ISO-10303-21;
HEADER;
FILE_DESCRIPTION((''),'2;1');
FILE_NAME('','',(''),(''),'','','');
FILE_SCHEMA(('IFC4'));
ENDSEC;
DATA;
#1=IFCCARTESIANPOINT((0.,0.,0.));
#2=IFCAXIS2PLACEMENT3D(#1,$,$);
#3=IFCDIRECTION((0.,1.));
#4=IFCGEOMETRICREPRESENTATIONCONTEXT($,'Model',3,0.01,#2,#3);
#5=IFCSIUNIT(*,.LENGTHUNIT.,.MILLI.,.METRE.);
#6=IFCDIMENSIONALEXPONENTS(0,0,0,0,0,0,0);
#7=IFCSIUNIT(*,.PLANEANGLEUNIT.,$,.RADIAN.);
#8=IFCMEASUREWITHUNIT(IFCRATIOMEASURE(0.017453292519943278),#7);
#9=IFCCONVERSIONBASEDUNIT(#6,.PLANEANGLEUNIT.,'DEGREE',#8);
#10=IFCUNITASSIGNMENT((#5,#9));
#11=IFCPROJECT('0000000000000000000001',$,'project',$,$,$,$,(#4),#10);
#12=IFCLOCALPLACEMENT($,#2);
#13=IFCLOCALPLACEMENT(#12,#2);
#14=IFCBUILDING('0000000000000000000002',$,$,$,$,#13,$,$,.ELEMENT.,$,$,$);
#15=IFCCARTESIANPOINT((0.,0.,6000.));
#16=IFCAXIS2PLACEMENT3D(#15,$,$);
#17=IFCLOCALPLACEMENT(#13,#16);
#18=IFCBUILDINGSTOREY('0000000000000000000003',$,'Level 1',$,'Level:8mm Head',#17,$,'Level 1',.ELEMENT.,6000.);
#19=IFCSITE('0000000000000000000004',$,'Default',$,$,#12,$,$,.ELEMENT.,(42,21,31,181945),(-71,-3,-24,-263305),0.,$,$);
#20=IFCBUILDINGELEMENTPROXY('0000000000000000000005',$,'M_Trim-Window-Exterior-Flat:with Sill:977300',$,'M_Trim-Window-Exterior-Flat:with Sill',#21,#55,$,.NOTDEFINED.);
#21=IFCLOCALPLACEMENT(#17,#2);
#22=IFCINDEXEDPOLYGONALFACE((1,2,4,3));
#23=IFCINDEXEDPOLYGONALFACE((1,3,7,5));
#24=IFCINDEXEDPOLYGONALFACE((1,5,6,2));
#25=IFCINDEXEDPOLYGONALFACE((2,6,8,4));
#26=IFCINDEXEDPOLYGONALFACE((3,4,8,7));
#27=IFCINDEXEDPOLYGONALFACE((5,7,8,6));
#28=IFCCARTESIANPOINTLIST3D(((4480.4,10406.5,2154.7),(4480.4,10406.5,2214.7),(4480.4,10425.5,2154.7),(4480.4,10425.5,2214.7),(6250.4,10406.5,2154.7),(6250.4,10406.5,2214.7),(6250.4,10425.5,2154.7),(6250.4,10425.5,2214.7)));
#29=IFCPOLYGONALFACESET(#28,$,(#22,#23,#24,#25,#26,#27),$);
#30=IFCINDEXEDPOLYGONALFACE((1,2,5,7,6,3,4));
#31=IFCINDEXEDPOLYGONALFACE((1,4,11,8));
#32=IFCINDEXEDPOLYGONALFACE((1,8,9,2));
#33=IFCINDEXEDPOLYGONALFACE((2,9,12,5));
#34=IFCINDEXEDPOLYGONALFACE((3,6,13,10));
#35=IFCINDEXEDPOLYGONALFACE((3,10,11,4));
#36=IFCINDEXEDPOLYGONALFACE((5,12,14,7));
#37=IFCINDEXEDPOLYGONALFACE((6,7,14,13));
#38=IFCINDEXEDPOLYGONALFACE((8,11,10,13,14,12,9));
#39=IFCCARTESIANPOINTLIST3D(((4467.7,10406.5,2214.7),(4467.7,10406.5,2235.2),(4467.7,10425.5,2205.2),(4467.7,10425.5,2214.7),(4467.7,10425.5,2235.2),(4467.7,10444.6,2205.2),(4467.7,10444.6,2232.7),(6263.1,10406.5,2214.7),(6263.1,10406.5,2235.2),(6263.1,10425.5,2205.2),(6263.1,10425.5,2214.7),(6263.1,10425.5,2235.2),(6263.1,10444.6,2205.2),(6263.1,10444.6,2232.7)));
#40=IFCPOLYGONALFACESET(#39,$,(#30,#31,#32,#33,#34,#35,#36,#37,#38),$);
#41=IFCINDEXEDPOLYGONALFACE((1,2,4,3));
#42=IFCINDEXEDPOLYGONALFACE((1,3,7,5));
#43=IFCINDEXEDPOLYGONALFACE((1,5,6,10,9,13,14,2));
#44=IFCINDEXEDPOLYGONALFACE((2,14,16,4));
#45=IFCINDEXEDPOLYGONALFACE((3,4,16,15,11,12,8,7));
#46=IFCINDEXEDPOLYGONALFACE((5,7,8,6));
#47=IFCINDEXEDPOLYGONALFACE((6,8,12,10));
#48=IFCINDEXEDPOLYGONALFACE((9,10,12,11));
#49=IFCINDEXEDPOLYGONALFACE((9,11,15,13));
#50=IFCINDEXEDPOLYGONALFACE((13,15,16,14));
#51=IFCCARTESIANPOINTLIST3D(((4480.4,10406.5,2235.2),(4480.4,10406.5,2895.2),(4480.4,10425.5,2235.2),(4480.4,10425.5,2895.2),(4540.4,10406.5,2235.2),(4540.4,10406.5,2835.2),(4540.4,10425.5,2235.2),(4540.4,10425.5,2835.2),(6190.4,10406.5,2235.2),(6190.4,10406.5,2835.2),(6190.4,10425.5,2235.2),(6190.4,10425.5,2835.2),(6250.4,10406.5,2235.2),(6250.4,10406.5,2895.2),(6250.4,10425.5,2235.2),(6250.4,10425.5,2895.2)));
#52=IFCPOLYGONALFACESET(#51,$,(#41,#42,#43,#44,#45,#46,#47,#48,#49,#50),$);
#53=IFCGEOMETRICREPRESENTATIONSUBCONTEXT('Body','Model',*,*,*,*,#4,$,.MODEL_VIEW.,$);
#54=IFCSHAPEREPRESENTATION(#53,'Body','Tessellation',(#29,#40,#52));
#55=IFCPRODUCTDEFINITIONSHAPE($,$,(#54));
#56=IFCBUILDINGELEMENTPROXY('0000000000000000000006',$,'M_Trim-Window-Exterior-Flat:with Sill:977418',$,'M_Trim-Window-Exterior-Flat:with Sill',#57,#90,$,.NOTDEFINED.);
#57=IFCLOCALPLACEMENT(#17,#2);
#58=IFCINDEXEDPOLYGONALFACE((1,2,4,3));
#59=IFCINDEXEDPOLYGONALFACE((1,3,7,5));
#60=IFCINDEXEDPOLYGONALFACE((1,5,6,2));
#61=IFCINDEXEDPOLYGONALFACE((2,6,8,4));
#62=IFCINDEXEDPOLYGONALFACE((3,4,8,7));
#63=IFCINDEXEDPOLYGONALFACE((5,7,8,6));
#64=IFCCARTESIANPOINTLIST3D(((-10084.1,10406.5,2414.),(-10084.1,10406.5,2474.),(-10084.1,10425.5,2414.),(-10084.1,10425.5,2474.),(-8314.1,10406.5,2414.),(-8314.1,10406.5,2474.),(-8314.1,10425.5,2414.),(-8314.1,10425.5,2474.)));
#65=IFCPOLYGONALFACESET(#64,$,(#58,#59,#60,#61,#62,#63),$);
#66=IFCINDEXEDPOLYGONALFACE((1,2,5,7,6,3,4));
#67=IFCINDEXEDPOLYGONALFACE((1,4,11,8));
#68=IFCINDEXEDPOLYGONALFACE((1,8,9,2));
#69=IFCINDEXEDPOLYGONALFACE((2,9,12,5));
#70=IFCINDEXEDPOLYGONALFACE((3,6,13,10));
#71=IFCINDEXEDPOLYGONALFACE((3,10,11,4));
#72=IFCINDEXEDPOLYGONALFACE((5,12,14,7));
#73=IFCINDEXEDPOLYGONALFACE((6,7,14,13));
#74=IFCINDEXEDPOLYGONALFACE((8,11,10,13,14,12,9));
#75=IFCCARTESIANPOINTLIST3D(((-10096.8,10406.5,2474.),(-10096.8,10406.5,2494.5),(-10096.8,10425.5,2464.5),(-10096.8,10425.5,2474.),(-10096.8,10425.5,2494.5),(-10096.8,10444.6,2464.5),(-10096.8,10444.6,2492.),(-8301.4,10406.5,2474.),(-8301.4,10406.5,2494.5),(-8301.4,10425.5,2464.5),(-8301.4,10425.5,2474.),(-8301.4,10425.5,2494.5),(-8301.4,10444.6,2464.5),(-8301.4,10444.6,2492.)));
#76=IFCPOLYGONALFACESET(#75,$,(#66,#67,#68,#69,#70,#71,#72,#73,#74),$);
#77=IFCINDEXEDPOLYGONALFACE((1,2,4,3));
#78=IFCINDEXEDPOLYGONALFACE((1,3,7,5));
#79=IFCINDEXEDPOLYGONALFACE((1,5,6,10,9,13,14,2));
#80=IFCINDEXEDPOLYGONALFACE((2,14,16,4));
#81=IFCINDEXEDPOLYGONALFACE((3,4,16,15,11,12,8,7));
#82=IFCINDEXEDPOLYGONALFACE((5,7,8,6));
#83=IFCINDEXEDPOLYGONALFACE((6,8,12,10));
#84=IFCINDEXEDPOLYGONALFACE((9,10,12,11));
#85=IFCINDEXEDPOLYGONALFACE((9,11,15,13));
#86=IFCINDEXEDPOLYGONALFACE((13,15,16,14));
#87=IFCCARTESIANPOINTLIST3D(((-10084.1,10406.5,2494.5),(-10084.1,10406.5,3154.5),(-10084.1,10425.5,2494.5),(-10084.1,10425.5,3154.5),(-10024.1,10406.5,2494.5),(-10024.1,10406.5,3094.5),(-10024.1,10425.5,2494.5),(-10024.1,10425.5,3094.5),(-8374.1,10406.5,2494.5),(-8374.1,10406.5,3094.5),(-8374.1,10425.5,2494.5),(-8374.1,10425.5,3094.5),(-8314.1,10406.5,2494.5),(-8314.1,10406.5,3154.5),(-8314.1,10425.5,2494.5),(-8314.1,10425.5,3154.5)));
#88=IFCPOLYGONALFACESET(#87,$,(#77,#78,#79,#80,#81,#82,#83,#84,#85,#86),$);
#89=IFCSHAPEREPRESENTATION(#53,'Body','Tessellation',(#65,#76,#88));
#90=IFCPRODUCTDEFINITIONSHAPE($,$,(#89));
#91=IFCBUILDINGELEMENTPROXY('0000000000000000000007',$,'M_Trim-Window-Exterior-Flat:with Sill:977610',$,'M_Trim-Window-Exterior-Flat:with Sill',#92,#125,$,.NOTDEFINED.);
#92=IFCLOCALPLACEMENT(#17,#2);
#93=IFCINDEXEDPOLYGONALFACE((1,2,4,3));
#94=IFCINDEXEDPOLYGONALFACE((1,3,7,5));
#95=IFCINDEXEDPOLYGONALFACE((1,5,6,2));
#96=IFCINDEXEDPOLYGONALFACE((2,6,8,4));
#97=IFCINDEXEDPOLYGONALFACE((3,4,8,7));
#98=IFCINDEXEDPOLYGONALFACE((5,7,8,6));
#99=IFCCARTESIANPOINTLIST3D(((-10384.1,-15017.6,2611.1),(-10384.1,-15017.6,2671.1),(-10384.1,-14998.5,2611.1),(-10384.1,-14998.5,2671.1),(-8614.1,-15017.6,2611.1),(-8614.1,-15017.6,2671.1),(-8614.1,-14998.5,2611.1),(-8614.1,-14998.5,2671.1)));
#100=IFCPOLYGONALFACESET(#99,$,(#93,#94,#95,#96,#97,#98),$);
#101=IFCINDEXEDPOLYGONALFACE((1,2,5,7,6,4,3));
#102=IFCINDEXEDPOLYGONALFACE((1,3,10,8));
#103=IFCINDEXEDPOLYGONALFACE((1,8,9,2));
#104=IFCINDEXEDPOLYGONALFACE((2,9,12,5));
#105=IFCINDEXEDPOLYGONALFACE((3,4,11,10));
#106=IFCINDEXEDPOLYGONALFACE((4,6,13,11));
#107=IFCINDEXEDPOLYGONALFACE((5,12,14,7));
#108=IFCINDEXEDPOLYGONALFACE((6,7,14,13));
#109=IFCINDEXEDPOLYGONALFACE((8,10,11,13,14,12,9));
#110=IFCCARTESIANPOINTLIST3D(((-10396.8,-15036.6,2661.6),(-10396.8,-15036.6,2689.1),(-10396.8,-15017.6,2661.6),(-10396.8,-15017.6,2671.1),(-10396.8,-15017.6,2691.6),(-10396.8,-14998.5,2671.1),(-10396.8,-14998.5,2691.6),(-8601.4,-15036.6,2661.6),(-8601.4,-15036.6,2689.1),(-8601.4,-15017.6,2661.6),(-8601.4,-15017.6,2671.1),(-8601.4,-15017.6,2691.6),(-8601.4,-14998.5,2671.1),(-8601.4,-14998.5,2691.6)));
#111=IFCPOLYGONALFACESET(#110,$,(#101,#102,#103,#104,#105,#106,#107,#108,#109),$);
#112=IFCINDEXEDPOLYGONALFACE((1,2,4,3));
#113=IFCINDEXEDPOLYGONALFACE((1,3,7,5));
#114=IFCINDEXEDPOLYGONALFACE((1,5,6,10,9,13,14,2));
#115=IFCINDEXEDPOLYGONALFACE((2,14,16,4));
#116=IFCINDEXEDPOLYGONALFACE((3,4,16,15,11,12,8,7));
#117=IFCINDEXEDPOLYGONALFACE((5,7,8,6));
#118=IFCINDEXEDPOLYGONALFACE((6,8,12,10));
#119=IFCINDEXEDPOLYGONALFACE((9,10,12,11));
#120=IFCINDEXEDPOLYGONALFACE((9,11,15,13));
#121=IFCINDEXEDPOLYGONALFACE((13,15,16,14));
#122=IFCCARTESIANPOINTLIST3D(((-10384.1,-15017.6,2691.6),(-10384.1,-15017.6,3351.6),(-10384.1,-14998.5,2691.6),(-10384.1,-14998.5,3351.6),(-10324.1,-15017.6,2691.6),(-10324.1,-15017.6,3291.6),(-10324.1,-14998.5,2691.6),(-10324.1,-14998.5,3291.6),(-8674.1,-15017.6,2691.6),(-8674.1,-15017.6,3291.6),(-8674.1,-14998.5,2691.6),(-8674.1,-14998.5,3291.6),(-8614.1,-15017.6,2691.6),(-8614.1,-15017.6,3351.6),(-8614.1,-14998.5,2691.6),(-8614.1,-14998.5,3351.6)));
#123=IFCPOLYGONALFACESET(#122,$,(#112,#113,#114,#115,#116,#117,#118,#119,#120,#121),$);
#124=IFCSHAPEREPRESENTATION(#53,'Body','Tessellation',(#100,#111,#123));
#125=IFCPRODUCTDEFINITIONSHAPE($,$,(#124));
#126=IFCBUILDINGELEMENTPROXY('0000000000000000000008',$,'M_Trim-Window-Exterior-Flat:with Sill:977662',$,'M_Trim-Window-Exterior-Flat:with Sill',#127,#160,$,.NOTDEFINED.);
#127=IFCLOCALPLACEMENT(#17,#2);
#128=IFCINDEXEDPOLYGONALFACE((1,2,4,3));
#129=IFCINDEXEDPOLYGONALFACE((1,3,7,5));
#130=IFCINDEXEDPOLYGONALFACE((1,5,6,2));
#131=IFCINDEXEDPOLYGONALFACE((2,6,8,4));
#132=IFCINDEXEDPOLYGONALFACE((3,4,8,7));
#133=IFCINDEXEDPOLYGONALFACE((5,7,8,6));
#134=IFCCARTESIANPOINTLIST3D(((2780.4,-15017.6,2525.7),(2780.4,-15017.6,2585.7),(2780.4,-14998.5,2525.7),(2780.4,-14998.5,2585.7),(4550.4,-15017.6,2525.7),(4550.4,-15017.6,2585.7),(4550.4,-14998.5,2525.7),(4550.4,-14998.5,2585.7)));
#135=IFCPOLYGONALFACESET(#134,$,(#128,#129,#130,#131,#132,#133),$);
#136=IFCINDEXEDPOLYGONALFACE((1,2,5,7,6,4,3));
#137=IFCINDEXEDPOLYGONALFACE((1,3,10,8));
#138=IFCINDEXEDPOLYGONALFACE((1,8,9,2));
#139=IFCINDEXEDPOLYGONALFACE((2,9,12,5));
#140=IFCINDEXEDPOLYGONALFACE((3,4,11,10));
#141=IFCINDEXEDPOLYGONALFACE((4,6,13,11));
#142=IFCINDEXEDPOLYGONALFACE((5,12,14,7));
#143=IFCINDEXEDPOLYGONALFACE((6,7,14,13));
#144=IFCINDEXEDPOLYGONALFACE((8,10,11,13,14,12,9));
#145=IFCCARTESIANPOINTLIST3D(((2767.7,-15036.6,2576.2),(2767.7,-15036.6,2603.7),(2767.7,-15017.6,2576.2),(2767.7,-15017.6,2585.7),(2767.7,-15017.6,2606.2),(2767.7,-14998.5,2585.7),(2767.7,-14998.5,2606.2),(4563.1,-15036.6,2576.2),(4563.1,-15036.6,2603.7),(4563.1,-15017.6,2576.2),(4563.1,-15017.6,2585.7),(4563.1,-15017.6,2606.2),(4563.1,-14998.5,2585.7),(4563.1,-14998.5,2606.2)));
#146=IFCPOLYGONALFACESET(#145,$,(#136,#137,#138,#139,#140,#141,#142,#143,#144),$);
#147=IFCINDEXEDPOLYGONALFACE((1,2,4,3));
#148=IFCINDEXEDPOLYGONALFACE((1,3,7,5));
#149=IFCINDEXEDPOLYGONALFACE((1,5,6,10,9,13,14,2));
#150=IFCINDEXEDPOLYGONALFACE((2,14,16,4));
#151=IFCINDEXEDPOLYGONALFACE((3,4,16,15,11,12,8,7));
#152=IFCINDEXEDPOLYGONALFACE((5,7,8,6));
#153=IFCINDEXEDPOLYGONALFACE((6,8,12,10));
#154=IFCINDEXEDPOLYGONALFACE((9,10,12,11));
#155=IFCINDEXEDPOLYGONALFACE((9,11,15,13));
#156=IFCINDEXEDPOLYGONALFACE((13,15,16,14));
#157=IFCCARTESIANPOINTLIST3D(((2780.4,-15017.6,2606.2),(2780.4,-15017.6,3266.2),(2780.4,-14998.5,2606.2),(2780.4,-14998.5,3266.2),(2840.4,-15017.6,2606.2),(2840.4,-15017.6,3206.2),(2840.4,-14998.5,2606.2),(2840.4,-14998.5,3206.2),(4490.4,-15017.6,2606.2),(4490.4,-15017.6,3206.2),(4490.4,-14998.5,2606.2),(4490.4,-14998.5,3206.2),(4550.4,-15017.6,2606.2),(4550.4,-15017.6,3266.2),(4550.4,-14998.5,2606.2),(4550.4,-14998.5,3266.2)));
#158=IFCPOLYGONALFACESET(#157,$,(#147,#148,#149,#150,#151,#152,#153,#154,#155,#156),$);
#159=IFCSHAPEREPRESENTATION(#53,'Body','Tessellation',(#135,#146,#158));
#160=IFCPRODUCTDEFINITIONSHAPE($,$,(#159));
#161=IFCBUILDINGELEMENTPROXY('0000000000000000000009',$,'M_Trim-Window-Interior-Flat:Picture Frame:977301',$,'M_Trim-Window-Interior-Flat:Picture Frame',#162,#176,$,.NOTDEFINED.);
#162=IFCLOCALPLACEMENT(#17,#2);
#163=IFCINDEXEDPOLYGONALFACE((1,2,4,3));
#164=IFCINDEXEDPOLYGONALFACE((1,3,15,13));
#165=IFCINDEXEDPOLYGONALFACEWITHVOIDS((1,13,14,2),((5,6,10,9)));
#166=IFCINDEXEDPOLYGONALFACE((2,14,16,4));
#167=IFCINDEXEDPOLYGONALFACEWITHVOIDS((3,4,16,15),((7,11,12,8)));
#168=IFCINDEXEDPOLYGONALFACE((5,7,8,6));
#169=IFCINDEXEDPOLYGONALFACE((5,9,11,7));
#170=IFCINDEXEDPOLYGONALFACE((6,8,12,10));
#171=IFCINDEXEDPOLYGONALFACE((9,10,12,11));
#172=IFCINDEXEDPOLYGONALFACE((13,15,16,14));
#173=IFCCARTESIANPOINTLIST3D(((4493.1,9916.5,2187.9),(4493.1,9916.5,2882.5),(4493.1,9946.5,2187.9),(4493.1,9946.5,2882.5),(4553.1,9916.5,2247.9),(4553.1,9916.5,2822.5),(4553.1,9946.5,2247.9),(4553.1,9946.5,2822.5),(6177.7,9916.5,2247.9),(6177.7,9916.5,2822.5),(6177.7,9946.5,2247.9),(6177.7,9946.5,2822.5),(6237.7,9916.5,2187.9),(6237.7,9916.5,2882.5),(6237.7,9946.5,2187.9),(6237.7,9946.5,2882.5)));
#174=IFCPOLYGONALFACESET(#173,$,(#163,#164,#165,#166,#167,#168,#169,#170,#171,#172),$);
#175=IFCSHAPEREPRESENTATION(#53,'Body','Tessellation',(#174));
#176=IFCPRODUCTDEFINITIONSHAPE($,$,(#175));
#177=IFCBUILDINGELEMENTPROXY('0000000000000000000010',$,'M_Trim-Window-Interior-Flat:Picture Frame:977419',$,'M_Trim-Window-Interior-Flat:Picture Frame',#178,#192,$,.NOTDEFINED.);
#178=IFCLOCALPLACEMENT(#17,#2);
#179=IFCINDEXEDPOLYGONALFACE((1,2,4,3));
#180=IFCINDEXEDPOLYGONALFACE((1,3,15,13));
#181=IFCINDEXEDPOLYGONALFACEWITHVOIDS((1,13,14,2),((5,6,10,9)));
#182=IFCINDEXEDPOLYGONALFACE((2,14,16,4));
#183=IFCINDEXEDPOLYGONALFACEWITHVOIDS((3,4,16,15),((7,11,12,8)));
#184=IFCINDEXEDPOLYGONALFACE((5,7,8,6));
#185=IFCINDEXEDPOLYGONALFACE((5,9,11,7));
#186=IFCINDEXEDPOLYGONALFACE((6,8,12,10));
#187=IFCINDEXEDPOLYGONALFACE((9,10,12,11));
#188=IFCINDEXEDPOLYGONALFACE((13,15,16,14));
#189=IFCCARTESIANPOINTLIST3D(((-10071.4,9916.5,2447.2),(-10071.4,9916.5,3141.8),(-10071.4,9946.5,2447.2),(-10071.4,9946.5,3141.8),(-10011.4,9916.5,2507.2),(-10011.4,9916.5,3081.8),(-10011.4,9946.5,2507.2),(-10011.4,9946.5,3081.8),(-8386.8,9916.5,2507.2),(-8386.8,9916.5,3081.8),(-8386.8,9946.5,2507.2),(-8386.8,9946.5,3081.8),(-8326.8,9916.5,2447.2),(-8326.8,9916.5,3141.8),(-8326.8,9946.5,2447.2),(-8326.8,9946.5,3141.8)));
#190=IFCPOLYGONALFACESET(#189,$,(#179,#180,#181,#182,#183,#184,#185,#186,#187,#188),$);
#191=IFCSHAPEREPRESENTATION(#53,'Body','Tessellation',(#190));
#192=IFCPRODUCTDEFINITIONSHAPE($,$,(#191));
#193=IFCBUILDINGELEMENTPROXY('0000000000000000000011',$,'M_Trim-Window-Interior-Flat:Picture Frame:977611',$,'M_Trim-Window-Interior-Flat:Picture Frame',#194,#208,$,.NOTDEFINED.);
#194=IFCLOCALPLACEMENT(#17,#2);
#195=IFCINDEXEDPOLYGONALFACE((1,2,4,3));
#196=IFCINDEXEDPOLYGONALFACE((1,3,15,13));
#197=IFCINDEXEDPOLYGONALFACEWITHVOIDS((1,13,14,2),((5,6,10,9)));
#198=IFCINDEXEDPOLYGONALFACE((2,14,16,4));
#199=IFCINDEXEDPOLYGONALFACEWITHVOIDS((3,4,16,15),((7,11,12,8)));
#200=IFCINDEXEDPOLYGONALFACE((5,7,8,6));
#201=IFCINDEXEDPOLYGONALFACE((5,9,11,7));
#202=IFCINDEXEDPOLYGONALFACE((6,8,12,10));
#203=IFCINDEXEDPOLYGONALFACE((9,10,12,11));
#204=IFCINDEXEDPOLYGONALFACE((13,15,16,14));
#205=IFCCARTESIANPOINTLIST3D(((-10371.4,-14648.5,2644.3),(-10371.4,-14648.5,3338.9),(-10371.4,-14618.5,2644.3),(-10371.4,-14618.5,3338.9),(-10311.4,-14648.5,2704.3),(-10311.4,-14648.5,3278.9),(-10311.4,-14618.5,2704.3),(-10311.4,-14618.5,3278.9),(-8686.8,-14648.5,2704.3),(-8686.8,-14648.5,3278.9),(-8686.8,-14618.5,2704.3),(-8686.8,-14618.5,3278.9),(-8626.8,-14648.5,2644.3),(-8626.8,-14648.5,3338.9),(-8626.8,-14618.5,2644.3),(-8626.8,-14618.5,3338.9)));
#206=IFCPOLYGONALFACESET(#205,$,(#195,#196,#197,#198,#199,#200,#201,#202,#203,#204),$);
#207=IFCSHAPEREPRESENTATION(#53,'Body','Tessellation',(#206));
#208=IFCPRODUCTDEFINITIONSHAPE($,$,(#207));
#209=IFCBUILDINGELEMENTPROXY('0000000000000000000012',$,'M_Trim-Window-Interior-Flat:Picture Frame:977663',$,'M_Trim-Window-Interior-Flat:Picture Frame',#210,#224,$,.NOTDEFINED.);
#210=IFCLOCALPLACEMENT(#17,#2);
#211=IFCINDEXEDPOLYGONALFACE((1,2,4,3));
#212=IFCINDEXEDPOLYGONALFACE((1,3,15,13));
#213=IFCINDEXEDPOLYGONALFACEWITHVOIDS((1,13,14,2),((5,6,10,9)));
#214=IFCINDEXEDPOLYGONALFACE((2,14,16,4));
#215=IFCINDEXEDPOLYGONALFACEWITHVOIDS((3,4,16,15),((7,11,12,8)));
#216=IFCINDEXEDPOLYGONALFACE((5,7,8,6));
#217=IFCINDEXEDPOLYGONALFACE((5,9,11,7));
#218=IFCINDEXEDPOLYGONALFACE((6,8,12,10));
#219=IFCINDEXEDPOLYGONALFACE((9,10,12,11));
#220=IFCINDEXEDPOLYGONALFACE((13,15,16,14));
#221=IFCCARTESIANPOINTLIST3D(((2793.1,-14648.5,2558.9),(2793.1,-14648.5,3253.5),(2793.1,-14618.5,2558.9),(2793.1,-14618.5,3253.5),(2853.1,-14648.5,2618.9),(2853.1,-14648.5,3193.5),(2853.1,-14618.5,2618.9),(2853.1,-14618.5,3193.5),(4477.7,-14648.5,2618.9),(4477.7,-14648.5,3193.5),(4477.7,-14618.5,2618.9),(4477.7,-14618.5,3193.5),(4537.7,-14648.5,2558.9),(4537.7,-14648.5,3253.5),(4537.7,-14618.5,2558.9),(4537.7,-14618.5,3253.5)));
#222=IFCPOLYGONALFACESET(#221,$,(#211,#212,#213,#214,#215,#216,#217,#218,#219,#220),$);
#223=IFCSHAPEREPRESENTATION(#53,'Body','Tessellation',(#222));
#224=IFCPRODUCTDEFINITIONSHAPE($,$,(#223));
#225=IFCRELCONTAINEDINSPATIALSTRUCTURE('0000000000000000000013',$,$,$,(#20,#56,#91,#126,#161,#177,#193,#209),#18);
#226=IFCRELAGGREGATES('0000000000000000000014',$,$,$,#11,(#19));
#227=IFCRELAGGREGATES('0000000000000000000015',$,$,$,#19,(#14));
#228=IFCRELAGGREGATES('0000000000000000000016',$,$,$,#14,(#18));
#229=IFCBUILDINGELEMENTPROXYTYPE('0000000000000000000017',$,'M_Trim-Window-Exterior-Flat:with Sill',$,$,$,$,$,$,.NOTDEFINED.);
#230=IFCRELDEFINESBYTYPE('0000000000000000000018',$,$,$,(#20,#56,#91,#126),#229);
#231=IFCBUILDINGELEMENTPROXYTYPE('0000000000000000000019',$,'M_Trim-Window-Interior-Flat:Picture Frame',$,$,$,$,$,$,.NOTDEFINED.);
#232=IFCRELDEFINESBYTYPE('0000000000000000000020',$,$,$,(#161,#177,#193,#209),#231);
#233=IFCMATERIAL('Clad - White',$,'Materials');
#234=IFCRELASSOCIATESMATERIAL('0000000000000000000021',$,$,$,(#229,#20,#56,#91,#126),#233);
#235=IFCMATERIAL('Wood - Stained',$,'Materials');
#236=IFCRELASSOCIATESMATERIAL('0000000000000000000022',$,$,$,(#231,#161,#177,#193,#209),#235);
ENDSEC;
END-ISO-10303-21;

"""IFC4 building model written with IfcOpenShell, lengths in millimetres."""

from ifc_helpers import new_model, entity, si_unit, converted_unit, direction, frame, origin, place, context, subcontext, project, spatial, indexed_curve, outline, extrude, source, transform, mapped, material, type_object, type_shapes, element, save


model = new_model("IFC4")

# Units and contexts
model_context = context("Model", 3, precision=0.01, world=origin(), true_north=direction((0.0, 1.0)))
body_context = subcontext(model_context, "Body", "Model", "MODEL_VIEW")
ifc_project = project(units=[si_unit("LENGTHUNIT", "METRE", prefix="MILLI"), converted_unit("PLANEANGLEUNIT", "DEGREE", entity("IfcRatioMeasure", 0.017453292519943278), si_unit("PLANEANGLEUNIT", "RADIAN"), dimensions=[0, 0, 0, 0, 0, 0, 0])], contexts=[model_context])

# Site, building, storey
site_placement = place(None, origin())
site = spatial("IfcSite", under=ifc_project, at=site_placement, Name="Default", CompositionType="ELEMENT", RefLatitude=(42, 21, 31, 181945), RefLongitude=(-71, -3, -24, -263305), RefElevation=0.0)
building_placement = place(site_placement, origin())
building = spatial("IfcBuilding", under=site, at=building_placement, CompositionType="ELEMENT")
storey_placement = place(building_placement, frame((0.0, 0.0, 6000.0)))
storey = spatial("IfcBuildingStorey", under=building, at=storey_placement, Name="Level 1", ObjectType="Level:8mm Head", LongName="Level 1", CompositionType="ELEMENT", Elevation=6000.0)

# Building element proxies
ifc_material_1 = material(Name="Clad - White", Category="Materials")
ifc_material_2 = material(Name="Wood - Stained", Category="Materials")
building_element_proxy_type_1 = type_object("IfcBuildingElementProxyType", Name="M_Trim-Window-Exterior-Flat:with Sill", PredefinedType="NOTDEFINED", material=ifc_material_1)
shared_shape_1 = source(origin(), body_context, "Body", "SweptSolid", [
    extrude(outline(indexed_curve([(-885.0, -30.0), (885.0, -30.0), (885.0, 30.0), (-885.0, 30.0), (-885.0, -30.0)], self_intersect=False)), frame((0.0, -650.4, 0.0), z_axis=(0.0, 0.0, 1.0), x_axis=(-1.0, 0.0, 0.0)), (0.0, 0.0, 1.0), 19.0),
    extrude(outline(indexed_curve([(-19.0, -15.2), (0.0, -15.2), (0.0, -5.7), (19.0, -5.7), (19.0, 14.8), (0.0, 14.8), (-19.0, 12.3), (-19.0, -15.2)], self_intersect=False)), frame((-897.7, -614.8, 19.0), z_axis=(1.0, 0.0, 0.0), x_axis=(0.0, 0.0, -1.0)), (0.0, 0.0, 1.0), 1795.4),
    extrude(outline(indexed_curve([(-345.0, -885.0), (315.0, -885.0), (315.0, -825.0), (-285.0, -825.0), (-285.0, 825.0), (315.0, 825.0), (315.0, 885.0), (-345.0, 885.0), (-345.0, -885.0)], self_intersect=False)), frame((0.0, -285.0, 0.0), z_axis=(0.0, 0.0, 1.0), x_axis=(0.0, -1.0, 0.0)), (0.0, 0.0, 1.0), 19.0),
])
type_shapes(building_element_proxy_type_1, [shared_shape_1])
for number, where, z_axis, x_axis, name in (
    (1, (5365.4, 10406.5, 2835.2), (0.0, 1.0, 0.0), (-1.0, 0.0, 0.0), "M_Trim-Window-Exterior-Flat:with Sill:977300"),
    (2, (-9199.1, 10406.5, 3094.5), (0.0, 1.0, 0.0), (-1.0, 0.0, 0.0), "M_Trim-Window-Exterior-Flat:with Sill:977418"),
    (3, (-9499.1, -14998.5, 3291.6), (0.0, -1.0, 0.0), (1.0, 0.0, 0.0), "M_Trim-Window-Exterior-Flat:with Sill:977610"),
    (4, (3665.4, -14998.5, 3206.2), (0.0, -1.0, 0.0), (1.0, 0.0, 0.0), "M_Trim-Window-Exterior-Flat:with Sill:977662"),
):
    element("IfcBuildingElementProxy", number, at=place(storey_placement, frame(where, z_axis=z_axis, x_axis=x_axis)), inside=storey, type_object=building_element_proxy_type_1, material=ifc_material_1, Name=name, ObjectType="M_Trim-Window-Exterior-Flat:with Sill", PredefinedType="NOTDEFINED", context=body_context, shape_type="MappedRepresentation", body=[
        mapped(shared_shape_1, transform((0.0, 0.0, 0.0), scale=1.0)),
    ])
building_element_proxy_type_2 = type_object("IfcBuildingElementProxyType", Name="M_Trim-Window-Interior-Flat:Picture Frame", PredefinedType="NOTDEFINED", material=ifc_material_2)
shared_shape_2 = source(origin(), body_context, "Body", "SweptSolid", [
    extrude(outline(indexed_curve([(-872.3, -347.3), (872.3, -347.3), (872.3, 347.3), (-872.3, 347.3), (-872.3, -347.3)], self_intersect=False), holes=[indexed_curve([(-812.3, -287.3), (-812.3, 287.3), (812.3, 287.3), (812.3, -287.3), (-812.3, -287.3)], self_intersect=False)]), frame((0.0, -300.0, 0.0), z_axis=(0.0, 0.0, 1.0), x_axis=(-1.0, 0.0, 0.0)), (0.0, 0.0, 1.0), 30.0),
])
type_shapes(building_element_proxy_type_2, [shared_shape_2])
for number, where, z_axis, x_axis, name in (
    (5, (5365.4, 9946.5, 2835.2), (0.0, -1.0, 0.0), (1.0, 0.0, 0.0), "M_Trim-Window-Interior-Flat:Picture Frame:977301"),
    (6, (-9199.1, 9946.5, 3094.5), (0.0, -1.0, 0.0), (1.0, 0.0, 0.0), "M_Trim-Window-Interior-Flat:Picture Frame:977419"),
    (7, (-9499.1, -14648.5, 3291.6), (0.0, 1.0, 0.0), (-1.0, 0.0, 0.0), "M_Trim-Window-Interior-Flat:Picture Frame:977611"),
    (8, (3665.4, -14648.5, 3206.2), (0.0, 1.0, 0.0), (-1.0, 0.0, 0.0), "M_Trim-Window-Interior-Flat:Picture Frame:977663"),
):
    element("IfcBuildingElementProxy", number, at=place(storey_placement, frame(where, z_axis=z_axis, x_axis=x_axis)), inside=storey, type_object=building_element_proxy_type_2, material=ifc_material_2, Name=name, ObjectType="M_Trim-Window-Interior-Flat:Picture Frame", PredefinedType="NOTDEFINED", context=body_context, shape_type="MappedRepresentation", body=[
        mapped(shared_shape_2, transform((0.0, 0.0, 0.0), scale=1.0)),
    ])

save(model, "model.ifc")
